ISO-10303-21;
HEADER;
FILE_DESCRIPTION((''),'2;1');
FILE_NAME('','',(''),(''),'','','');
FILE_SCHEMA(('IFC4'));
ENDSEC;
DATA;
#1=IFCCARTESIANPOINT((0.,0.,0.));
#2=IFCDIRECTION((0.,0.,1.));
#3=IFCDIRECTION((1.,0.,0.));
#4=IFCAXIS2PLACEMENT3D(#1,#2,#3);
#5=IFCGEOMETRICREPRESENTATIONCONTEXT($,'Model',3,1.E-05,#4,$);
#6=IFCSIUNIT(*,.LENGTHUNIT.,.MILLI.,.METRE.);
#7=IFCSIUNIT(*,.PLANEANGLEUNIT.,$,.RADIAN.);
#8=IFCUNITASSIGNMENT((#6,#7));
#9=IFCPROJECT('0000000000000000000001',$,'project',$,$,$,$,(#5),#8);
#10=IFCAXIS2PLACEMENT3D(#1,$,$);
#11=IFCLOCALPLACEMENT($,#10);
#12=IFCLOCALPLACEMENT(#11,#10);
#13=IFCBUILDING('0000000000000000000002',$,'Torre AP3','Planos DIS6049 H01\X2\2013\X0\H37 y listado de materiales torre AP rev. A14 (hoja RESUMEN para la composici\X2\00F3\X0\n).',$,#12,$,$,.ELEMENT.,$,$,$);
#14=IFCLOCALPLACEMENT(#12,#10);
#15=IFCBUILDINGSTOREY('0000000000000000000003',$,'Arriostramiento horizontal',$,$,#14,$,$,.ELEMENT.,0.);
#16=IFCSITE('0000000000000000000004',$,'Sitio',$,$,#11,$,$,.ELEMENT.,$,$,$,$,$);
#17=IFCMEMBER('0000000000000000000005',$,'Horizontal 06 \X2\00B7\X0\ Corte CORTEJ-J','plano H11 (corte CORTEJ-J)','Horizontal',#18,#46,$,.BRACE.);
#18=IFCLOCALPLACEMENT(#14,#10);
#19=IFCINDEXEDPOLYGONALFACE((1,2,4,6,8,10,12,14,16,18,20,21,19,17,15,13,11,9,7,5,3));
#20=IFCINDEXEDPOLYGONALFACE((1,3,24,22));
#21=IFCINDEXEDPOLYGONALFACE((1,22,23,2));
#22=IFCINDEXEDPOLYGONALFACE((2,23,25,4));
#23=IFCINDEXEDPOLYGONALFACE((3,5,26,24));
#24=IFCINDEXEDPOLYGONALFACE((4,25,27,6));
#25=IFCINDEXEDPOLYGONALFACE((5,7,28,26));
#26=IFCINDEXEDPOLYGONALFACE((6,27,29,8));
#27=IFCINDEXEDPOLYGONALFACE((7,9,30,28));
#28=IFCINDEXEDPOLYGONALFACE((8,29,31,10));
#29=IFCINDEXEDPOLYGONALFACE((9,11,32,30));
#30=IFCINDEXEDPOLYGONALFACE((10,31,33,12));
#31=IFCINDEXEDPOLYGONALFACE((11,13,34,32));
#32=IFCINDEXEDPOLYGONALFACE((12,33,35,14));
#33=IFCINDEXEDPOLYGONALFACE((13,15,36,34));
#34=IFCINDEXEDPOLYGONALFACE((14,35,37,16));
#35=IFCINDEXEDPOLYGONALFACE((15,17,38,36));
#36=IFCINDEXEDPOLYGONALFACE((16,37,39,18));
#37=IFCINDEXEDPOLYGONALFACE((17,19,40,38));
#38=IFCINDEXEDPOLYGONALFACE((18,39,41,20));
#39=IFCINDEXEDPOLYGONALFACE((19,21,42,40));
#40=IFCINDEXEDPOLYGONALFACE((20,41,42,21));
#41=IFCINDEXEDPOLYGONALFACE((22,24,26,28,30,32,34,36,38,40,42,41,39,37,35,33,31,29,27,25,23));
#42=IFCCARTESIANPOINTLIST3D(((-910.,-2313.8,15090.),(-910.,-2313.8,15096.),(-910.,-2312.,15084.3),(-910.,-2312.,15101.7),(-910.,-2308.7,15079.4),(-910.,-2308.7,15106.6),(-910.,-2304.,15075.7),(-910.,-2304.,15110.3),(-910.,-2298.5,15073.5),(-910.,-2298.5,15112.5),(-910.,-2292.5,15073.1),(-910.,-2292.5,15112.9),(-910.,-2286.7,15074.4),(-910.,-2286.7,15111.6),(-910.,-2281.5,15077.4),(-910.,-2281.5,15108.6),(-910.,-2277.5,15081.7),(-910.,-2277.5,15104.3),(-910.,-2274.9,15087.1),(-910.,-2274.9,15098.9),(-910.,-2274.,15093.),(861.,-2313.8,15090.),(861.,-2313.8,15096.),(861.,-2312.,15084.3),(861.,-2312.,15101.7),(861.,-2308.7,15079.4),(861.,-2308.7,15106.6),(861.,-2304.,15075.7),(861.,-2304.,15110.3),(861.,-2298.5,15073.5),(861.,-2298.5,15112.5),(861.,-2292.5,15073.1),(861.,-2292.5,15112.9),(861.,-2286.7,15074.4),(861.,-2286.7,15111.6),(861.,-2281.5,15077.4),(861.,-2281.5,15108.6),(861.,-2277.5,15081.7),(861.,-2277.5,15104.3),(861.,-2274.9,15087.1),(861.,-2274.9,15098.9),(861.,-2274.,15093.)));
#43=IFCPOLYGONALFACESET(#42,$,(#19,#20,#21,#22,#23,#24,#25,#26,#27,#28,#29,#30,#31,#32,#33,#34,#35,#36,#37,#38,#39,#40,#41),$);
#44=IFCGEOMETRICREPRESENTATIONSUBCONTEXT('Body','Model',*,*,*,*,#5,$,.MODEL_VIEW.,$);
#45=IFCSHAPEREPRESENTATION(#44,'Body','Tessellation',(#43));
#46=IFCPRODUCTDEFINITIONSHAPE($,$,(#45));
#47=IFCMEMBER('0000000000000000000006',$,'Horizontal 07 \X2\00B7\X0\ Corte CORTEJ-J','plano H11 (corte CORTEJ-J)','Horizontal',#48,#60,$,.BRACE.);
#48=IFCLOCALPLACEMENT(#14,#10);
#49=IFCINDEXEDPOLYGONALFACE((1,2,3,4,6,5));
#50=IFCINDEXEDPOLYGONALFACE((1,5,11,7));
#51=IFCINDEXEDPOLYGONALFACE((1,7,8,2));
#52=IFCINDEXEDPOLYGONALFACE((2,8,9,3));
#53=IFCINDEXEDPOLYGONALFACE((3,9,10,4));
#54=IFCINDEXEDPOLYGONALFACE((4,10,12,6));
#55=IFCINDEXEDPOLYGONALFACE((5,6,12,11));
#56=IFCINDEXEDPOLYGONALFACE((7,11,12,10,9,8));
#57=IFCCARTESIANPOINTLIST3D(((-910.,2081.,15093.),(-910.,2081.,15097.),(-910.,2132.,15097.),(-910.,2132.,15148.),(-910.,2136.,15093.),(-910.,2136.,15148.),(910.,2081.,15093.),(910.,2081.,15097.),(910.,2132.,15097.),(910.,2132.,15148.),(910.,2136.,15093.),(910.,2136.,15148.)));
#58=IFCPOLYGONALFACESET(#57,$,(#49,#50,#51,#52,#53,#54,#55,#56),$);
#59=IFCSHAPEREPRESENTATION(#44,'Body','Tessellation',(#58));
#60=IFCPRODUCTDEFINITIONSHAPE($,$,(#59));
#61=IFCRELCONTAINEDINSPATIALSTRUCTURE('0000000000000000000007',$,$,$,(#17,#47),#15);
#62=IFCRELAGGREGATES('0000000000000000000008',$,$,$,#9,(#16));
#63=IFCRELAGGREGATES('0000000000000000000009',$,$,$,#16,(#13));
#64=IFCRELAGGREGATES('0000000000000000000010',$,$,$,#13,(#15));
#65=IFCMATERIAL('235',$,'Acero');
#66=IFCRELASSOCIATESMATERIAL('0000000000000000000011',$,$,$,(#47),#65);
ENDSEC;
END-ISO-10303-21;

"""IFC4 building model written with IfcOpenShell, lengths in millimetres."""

from ifc_helpers import new_model, si_unit, frame, frame_2d, origin, origin_with_axes, place, context, subcontext, project, spatial, circle, l_section, extrude, material, element, save


model = new_model("IFC4")

# Units and contexts
model_context = context("Model", 3, precision=1e-05, world=origin_with_axes())
body_context = subcontext(model_context, "Body", "Model", "MODEL_VIEW")
ifc_project = project(units=[si_unit("LENGTHUNIT", "METRE", prefix="MILLI"), si_unit("PLANEANGLEUNIT", "RADIAN")], contexts=[model_context])

# Site, building, storey
site_placement = place(None, origin())
site = spatial("IfcSite", under=ifc_project, at=site_placement, Name="Sitio", CompositionType="ELEMENT")
building_placement = place(site_placement, origin())
building = spatial("IfcBuilding", under=site, at=building_placement, Name="Torre AP3", Description="Planos DIS6049 H01–H37 y listado de materiales torre AP rev. A14 (hoja RESUMEN para la composición).", CompositionType="ELEMENT")
storey_placement = place(building_placement, origin())
storey = spatial("IfcBuildingStorey", under=building, at=storey_placement, Name="Arriostramiento horizontal", CompositionType="ELEMENT", Elevation=0.0)

# Members
ifc_material = material(Name="235", Category="Acero")
member_1_placement = place(storey_placement, frame((861.0, -2294.0, 15093.0), z_axis=(-1.0, 0.0, 0.0), x_axis=(0.0, 1.0, 0.0)))
element("IfcMember", 1, at=member_1_placement, inside=storey, Name="Horizontal 06 · Corte CORTEJ-J", Description="plano H11 (corte CORTEJ-J)", ObjectType="Horizontal", PredefinedType="BRACE", context=body_context, shape_type="SweptSolid", body=[
    extrude(circle(Radius=20.0), None, (0.0, 0.0, 1.0), 1771.0),
])
member_2_placement = place(storey_placement, frame((910.0, 2136.0, 15093.0), z_axis=(-1.0, 0.0, 0.0), x_axis=(0.0, -1.0, 0.0)))
element("IfcMember", 2, at=member_2_placement, inside=storey, material=ifc_material, Name="Horizontal 07 · Corte CORTEJ-J", Description="plano H11 (corte CORTEJ-J)", ObjectType="Horizontal", PredefinedType="BRACE", context=body_context, shape_type="SweptSolid", body=[
    extrude(l_section(Depth=55.0, Width=55.0, Thickness=4.0, at=frame_2d((27.5, 27.5))), None, (0.0, 0.0, 1.0), 1820.0),
])

save(model, "model.ifc")
